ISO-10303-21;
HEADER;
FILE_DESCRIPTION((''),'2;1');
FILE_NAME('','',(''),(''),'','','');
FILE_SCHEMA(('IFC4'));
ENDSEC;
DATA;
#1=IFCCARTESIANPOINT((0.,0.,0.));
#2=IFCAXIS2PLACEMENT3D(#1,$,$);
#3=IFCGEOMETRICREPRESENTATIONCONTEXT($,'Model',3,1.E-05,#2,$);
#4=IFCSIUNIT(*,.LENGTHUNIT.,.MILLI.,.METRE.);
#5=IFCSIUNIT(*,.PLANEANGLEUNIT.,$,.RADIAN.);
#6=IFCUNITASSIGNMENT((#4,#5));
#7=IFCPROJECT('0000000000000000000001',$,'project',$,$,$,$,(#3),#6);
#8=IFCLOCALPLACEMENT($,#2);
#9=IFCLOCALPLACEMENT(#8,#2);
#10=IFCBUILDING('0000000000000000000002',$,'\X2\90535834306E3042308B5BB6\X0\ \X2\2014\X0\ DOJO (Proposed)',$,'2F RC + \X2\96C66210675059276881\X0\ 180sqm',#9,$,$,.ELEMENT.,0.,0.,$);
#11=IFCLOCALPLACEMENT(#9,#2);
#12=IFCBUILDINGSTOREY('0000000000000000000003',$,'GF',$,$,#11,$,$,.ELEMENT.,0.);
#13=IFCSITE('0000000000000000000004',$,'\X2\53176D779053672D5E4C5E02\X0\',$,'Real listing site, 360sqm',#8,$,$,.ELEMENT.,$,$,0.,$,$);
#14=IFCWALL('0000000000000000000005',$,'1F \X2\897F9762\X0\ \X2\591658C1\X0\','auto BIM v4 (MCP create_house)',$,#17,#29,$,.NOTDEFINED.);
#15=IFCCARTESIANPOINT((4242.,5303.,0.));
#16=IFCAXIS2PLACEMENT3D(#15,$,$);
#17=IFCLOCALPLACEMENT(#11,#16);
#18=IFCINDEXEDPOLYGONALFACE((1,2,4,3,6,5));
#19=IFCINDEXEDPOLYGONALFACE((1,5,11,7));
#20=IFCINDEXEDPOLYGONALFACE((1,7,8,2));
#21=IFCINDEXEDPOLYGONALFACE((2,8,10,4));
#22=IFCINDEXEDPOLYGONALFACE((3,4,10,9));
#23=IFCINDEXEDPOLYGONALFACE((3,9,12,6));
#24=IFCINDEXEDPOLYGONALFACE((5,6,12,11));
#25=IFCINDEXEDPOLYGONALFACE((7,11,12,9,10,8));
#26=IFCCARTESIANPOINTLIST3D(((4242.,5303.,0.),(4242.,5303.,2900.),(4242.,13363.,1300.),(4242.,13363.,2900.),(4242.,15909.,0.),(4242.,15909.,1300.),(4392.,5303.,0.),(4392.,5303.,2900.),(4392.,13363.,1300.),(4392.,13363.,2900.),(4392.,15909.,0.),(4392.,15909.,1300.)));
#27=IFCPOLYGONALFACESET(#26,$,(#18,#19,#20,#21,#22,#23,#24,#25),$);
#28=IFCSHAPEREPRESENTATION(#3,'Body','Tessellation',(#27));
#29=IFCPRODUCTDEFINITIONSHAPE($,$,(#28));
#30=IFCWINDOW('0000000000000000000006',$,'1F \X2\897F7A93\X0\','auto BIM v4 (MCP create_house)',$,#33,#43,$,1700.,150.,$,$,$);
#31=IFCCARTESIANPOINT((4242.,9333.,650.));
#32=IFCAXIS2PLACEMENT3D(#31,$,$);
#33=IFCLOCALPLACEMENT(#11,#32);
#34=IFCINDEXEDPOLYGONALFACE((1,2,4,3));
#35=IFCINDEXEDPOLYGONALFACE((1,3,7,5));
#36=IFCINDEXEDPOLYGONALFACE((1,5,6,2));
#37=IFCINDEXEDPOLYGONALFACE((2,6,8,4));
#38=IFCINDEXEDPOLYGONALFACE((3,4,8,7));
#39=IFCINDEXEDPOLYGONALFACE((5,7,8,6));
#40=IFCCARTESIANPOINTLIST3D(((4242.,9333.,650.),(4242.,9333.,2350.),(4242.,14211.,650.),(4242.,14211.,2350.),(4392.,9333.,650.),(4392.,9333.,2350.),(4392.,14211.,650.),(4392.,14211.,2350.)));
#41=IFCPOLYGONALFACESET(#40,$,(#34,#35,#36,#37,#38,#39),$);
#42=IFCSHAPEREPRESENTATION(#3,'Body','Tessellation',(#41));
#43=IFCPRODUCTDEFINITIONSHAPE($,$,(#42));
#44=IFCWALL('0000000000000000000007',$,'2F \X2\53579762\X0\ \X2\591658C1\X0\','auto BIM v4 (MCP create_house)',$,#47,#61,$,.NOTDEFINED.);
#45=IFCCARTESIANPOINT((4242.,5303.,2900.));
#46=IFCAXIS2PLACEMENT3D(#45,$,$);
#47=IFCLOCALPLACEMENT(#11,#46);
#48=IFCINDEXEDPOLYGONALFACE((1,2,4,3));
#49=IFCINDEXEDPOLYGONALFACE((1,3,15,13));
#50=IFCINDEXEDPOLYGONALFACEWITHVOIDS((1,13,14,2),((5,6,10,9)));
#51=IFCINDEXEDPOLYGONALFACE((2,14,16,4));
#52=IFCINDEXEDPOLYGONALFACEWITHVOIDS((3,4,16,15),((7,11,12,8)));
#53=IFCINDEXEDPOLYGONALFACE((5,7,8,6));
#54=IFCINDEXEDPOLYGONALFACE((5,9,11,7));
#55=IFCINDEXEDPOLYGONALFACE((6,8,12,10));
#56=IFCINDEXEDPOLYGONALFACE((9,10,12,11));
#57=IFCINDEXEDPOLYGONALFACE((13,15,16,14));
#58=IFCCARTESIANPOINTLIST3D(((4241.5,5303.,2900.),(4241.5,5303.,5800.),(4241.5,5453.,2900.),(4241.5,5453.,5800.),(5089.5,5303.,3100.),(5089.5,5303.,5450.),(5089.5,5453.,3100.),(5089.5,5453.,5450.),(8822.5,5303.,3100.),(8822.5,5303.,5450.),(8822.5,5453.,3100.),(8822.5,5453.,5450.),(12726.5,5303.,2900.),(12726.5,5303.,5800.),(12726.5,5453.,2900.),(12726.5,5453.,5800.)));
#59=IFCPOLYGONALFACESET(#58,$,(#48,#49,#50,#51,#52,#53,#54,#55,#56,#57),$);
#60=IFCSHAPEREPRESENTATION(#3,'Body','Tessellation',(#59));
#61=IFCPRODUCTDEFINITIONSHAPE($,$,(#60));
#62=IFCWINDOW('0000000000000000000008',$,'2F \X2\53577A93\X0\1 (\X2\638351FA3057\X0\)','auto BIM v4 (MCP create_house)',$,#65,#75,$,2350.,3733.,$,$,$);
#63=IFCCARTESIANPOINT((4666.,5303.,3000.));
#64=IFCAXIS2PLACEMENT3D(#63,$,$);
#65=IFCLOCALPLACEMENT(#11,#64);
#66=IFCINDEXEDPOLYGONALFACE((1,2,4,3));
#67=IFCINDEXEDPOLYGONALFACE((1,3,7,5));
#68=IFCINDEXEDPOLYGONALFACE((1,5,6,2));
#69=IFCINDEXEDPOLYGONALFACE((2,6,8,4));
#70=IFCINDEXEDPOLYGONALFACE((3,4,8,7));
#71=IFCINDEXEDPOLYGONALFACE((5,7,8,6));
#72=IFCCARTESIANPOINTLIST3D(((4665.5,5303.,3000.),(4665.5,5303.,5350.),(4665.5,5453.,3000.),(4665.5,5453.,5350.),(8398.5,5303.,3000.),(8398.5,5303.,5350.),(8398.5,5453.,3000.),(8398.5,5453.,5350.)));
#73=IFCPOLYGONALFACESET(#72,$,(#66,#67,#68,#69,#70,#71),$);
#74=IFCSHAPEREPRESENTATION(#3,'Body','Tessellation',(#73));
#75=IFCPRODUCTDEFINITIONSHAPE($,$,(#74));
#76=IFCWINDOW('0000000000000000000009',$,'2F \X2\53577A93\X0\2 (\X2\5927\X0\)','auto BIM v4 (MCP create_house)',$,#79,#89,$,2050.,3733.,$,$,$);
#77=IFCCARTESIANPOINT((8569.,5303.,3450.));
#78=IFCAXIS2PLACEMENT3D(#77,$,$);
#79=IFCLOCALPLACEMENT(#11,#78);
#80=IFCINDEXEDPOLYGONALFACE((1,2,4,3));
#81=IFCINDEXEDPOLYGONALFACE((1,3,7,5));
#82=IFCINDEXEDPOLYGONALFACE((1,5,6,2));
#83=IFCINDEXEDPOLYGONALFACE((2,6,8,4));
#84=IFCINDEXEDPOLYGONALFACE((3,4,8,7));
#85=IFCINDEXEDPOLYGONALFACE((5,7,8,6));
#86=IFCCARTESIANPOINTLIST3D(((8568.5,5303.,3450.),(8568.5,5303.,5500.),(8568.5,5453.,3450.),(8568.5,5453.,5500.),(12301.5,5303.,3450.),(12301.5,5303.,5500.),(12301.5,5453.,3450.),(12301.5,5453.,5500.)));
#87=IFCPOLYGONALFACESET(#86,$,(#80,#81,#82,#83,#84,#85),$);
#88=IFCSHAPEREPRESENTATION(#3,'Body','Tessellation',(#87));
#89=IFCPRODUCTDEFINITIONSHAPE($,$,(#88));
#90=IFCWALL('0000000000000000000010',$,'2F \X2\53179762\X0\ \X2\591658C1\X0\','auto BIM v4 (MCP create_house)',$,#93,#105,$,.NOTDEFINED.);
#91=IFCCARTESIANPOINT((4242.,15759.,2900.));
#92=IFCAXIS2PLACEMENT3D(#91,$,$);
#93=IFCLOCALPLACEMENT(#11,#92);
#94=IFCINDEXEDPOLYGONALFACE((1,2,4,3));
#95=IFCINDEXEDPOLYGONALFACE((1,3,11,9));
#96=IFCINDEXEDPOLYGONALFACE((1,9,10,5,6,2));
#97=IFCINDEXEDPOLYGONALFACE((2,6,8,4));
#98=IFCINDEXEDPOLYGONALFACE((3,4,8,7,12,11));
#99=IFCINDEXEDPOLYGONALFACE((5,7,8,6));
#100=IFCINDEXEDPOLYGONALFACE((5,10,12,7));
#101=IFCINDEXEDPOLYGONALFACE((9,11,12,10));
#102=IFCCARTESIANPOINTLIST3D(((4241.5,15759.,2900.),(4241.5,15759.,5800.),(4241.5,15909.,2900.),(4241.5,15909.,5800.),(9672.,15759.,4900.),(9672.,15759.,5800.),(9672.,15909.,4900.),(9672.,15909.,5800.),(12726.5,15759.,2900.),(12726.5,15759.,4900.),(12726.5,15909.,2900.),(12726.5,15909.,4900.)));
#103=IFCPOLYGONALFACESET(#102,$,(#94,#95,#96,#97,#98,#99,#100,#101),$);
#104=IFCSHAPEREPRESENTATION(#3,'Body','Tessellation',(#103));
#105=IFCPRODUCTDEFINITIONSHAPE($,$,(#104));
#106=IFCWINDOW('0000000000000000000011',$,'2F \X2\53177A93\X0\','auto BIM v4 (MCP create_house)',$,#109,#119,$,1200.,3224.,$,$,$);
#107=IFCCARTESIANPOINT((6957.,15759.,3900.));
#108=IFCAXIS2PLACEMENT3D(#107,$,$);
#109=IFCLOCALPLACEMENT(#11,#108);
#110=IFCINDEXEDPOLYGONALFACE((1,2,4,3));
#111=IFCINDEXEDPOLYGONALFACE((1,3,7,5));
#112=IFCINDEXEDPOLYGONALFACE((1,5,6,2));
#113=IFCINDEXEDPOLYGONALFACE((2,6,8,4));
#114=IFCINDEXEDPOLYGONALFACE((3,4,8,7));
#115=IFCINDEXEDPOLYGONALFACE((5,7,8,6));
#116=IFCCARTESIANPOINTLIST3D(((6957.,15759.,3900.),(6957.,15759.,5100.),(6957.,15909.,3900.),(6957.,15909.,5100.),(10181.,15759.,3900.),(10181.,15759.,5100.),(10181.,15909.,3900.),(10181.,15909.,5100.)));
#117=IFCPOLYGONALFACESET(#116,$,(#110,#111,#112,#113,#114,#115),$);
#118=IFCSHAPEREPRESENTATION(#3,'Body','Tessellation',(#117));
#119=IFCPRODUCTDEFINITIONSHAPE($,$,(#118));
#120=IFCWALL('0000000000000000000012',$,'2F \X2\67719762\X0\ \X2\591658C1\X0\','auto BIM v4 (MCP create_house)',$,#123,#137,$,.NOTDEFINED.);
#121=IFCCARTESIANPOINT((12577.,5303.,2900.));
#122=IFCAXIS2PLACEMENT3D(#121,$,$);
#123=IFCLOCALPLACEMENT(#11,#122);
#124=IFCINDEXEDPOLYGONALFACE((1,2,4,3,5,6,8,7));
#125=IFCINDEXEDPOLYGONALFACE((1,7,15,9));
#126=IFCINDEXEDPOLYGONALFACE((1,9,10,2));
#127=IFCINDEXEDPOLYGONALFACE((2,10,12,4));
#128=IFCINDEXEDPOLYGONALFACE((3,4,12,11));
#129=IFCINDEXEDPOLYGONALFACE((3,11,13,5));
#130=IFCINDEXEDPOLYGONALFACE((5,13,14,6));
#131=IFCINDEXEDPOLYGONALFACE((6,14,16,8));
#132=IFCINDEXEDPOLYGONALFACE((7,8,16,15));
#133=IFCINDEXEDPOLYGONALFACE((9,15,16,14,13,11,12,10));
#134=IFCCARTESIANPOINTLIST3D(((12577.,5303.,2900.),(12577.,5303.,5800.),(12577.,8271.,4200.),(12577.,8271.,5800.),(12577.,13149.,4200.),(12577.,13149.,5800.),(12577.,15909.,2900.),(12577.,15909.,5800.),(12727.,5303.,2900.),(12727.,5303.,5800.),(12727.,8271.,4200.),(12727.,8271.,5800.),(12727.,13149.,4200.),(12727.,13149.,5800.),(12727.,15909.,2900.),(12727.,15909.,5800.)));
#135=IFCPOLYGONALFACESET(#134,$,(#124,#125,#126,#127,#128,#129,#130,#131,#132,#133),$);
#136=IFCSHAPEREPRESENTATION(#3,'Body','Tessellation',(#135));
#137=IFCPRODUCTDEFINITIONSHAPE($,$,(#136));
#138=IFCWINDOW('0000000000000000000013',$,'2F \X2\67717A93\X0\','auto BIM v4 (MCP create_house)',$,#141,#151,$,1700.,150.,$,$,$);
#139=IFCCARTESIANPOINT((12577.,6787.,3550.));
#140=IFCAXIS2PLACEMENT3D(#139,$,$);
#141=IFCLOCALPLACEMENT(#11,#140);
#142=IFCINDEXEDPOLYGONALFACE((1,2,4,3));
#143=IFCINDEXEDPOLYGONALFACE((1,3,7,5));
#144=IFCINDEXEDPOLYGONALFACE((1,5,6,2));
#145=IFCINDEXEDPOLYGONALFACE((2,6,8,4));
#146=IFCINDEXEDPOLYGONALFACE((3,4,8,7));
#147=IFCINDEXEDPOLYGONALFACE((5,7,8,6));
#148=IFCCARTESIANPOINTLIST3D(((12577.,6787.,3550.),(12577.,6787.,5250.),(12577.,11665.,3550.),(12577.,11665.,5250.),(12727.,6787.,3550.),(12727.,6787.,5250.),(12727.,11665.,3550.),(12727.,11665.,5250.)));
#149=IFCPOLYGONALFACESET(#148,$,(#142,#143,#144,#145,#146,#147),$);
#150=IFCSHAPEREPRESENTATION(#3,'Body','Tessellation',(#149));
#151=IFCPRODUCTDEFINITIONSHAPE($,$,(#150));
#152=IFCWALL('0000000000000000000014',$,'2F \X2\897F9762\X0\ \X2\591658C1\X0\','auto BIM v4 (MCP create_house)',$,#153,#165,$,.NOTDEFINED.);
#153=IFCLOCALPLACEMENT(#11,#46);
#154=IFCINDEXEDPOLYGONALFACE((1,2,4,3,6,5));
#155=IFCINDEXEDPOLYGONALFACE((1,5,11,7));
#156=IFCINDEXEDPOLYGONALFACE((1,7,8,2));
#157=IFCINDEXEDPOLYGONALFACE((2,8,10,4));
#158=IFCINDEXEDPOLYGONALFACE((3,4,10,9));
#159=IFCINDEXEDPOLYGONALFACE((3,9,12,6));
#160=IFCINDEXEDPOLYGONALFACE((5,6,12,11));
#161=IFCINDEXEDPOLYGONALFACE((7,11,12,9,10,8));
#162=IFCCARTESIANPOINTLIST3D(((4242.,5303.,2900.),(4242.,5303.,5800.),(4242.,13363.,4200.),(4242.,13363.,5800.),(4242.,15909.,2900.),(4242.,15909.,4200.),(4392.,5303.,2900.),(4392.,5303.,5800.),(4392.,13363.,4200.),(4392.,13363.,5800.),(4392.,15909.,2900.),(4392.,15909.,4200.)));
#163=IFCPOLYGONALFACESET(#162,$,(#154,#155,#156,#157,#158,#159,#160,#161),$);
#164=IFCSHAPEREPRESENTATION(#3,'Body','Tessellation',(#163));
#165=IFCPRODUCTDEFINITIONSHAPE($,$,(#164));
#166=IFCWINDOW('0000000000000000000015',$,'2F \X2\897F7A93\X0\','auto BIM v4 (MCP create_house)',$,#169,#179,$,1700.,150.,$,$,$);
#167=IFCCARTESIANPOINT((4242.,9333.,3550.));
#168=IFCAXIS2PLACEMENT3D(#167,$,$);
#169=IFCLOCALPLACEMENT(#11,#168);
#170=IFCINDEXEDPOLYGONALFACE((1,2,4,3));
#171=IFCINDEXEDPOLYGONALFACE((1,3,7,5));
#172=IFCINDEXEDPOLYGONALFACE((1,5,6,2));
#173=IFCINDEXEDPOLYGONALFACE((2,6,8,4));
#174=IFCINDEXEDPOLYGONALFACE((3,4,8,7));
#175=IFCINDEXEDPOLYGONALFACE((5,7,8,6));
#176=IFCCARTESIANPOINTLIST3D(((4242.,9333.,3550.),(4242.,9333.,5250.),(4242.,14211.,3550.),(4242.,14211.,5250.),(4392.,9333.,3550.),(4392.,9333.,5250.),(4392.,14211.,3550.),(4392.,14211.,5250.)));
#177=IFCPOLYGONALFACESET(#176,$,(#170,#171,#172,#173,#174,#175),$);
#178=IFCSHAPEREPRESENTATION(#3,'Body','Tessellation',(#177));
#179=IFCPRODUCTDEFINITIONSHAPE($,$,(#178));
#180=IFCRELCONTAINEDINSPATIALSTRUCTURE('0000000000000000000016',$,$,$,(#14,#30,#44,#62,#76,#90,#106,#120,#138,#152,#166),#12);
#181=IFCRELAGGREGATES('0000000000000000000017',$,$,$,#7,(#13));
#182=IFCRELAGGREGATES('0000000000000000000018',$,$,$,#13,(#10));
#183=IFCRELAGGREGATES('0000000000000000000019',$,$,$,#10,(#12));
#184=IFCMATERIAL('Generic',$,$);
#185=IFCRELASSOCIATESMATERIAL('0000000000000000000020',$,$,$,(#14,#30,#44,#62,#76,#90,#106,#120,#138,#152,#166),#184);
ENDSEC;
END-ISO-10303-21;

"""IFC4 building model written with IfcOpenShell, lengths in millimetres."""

from ifc_helpers import new_model, si_unit, frame, frame_2d, origin, place, context, project, spatial, rectangle, extrude, material, element, fill, save


model = new_model("IFC4")

# Units and contexts
model_context = context("Model", 3, precision=1e-05, world=origin())
ifc_project = project(units=[si_unit("LENGTHUNIT", "METRE", prefix="MILLI"), si_unit("PLANEANGLEUNIT", "RADIAN")], contexts=[model_context])

# Site, building, storey
site_placement = place(None, origin())
site = spatial("IfcSite", under=ifc_project, at=site_placement, Name="北海道札幌市", ObjectType="Real listing site, 360sqm", CompositionType="ELEMENT", RefElevation=0.0)
building_placement = place(site_placement, origin())
building = spatial("IfcBuilding", under=site, at=building_placement, Name="道場のある家 — DOJO (Proposed)", ObjectType="2F RC + 集成材大梁 180sqm", CompositionType="ELEMENT", ElevationOfRefHeight=0.0, ElevationOfTerrain=0.0)
storey_placement = place(building_placement, origin())
storey = spatial("IfcBuildingStorey", under=building, at=storey_placement, Name="GF", CompositionType="ELEMENT", Elevation=0.0)

# Shared definitions
ifc_material = material(Name="Generic")

# Wall, opening, window
wall_1_placement = place(storey_placement, frame((4242.0, 5303.0, 0.0)))
wall_1 = element("IfcWall", 1, at=wall_1_placement, inside=storey, material=ifc_material, Name="1F 西面 外壁", Description="auto BIM v4 (MCP create_house)", PredefinedType="NOTDEFINED", context=model_context, shape_type="SweptSolid", body=[
    extrude(rectangle(XDim=150.0, YDim=10606.0, at=frame_2d((75.0, 5303.0))), frame((4242.0, 5303.0, 0.0)), (0.0, 0.0, 1.0), 2900.0),
])
opening_1_placement = place(storey_placement, frame((4242.0, 9333.0, 650.0)))
opening_1 = element("IfcOpeningElement", 2, at=opening_1_placement, cuts=wall_1, PredefinedType="NOTDEFINED", context=model_context, shape_type="SweptSolid", body=[
    extrude(rectangle(XDim=150.0, YDim=4878.0, at=frame_2d((75.0, 2439.0))), frame((4242.0, 9333.0, 650.0)), (0.0, 0.0, 1.0), 1700.0),
])
window_1_placement = place(storey_placement, frame((4242.0, 9333.0, 650.0)))
window_1 = element("IfcWindow", 3, at=window_1_placement, inside=storey, material=ifc_material, Name="1F 西窓", Description="auto BIM v4 (MCP create_house)", OverallHeight=1700.0, OverallWidth=150.0, context=model_context, shape_type="SweptSolid", body=[
    extrude(rectangle(XDim=150.0, YDim=4878.0, at=frame_2d((75.0, 2439.0))), frame((4242.0, 9333.0, 650.0)), (0.0, 0.0, 1.0), 1700.0),
])
fill(opening_1, window_1)

# Wall, openings, windows
wall_2_placement = place(storey_placement, frame((4242.0, 5303.0, 2900.0)))
wall_2 = element("IfcWall", 4, at=wall_2_placement, inside=storey, material=ifc_material, Name="2F 南面 外壁", Description="auto BIM v4 (MCP create_house)", PredefinedType="NOTDEFINED", context=model_context, shape_type="SweptSolid", body=[
    extrude(rectangle(XDim=8485.0, YDim=150.0, at=frame_2d((4242.0, 75.0))), frame((4242.0, 5303.0, 2900.0)), (0.0, 0.0, 1.0), 2900.0),
])
opening_2_placement = place(storey_placement, frame((4666.0, 5303.0, 3000.0)))
opening_2 = element("IfcOpeningElement", 5, at=opening_2_placement, cuts=wall_2, PredefinedType="NOTDEFINED", context=model_context, shape_type="SweptSolid", body=[
    extrude(rectangle(XDim=3733.0, YDim=150.0, at=frame_2d((1866.0, 75.0))), frame((4666.0, 5303.0, 3000.0)), (0.0, 0.0, 1.0), 2350.0),
])
opening_3_placement = place(storey_placement, frame((8569.0, 5303.0, 3450.0)))
opening_3 = element("IfcOpeningElement", 6, at=opening_3_placement, cuts=wall_2, PredefinedType="NOTDEFINED", context=model_context, shape_type="SweptSolid", body=[
    extrude(rectangle(XDim=3733.0, YDim=150.0, at=frame_2d((1866.0, 75.0))), frame((8569.0, 5303.0, 3450.0)), (0.0, 0.0, 1.0), 2050.0),
])
window_2_placement = place(storey_placement, frame((4666.0, 5303.0, 3000.0)))
window_2 = element("IfcWindow", 7, at=window_2_placement, inside=storey, material=ifc_material, Name="2F 南窓1 (掃出し)", Description="auto BIM v4 (MCP create_house)", OverallHeight=2350.0, OverallWidth=3733.0, context=model_context, shape_type="SweptSolid", body=[
    extrude(rectangle(XDim=3733.0, YDim=150.0, at=frame_2d((1866.0, 75.0))), frame((4666.0, 5303.0, 3000.0)), (0.0, 0.0, 1.0), 2350.0),
])
fill(opening_2, window_2)
window_3_placement = place(storey_placement, frame((8569.0, 5303.0, 3450.0)))
window_3 = element("IfcWindow", 8, at=window_3_placement, inside=storey, material=ifc_material, Name="2F 南窓2 (大)", Description="auto BIM v4 (MCP create_house)", OverallHeight=2050.0, OverallWidth=3733.0, context=model_context, shape_type="SweptSolid", body=[
    extrude(rectangle(XDim=3733.0, YDim=150.0, at=frame_2d((1866.0, 75.0))), frame((8569.0, 5303.0, 3450.0)), (0.0, 0.0, 1.0), 2050.0),
])
fill(opening_3, window_3)

# Walls, openings, windows
wall_3_placement = place(storey_placement, frame((4242.0, 15759.0, 2900.0)))
wall_3 = element("IfcWall", 9, at=wall_3_placement, inside=storey, material=ifc_material, Name="2F 北面 外壁", Description="auto BIM v4 (MCP create_house)", PredefinedType="NOTDEFINED", context=model_context, shape_type="SweptSolid", body=[
    extrude(rectangle(XDim=8485.0, YDim=150.0, at=frame_2d((4242.0, 75.0))), frame((4242.0, 15759.0, 2900.0)), (0.0, 0.0, 1.0), 2900.0),
])
opening_4_placement = place(storey_placement, frame((6957.0, 15759.0, 3900.0)))
opening_4 = element("IfcOpeningElement", 10, at=opening_4_placement, cuts=wall_3, PredefinedType="NOTDEFINED", context=model_context, shape_type="SweptSolid", body=[
    extrude(rectangle(XDim=3224.0, YDim=150.0, at=frame_2d((1612.0, 75.0))), frame((6957.0, 15759.0, 3900.0)), (0.0, 0.0, 1.0), 1200.0),
])
window_4_placement = place(storey_placement, frame((6957.0, 15759.0, 3900.0)))
window_4 = element("IfcWindow", 11, at=window_4_placement, inside=storey, material=ifc_material, Name="2F 北窓", Description="auto BIM v4 (MCP create_house)", OverallHeight=1200.0, OverallWidth=3224.0, context=model_context, shape_type="SweptSolid", body=[
    extrude(rectangle(XDim=3224.0, YDim=150.0, at=frame_2d((1612.0, 75.0))), frame((6957.0, 15759.0, 3900.0)), (0.0, 0.0, 1.0), 1200.0),
])
fill(opening_4, window_4)
wall_4_placement = place(storey_placement, frame((12577.0, 5303.0, 2900.0)))
wall_4 = element("IfcWall", 12, at=wall_4_placement, inside=storey, material=ifc_material, Name="2F 東面 外壁", Description="auto BIM v4 (MCP create_house)", PredefinedType="NOTDEFINED", context=model_context, shape_type="SweptSolid", body=[
    extrude(rectangle(XDim=150.0, YDim=10606.0, at=frame_2d((75.0, 5303.0))), frame((12577.0, 5303.0, 2900.0)), (0.0, 0.0, 1.0), 2900.0),
])
opening_5_placement = place(storey_placement, frame((12577.0, 6787.0, 3550.0)))
opening_5 = element("IfcOpeningElement", 13, at=opening_5_placement, cuts=wall_4, PredefinedType="NOTDEFINED", context=model_context, shape_type="SweptSolid", body=[
    extrude(rectangle(XDim=150.0, YDim=4878.0, at=frame_2d((75.0, 2439.0))), frame((12577.0, 6787.0, 3550.0)), (0.0, 0.0, 1.0), 1700.0),
])
window_5_placement = place(storey_placement, frame((12577.0, 6787.0, 3550.0)))
window_5 = element("IfcWindow", 14, at=window_5_placement, inside=storey, material=ifc_material, Name="2F 東窓", Description="auto BIM v4 (MCP create_house)", OverallHeight=1700.0, OverallWidth=150.0, context=model_context, shape_type="SweptSolid", body=[
    extrude(rectangle(XDim=150.0, YDim=4878.0, at=frame_2d((75.0, 2439.0))), frame((12577.0, 6787.0, 3550.0)), (0.0, 0.0, 1.0), 1700.0),
])
fill(opening_5, window_5)
wall_5_placement = place(storey_placement, frame((4242.0, 5303.0, 2900.0)))
wall_5 = element("IfcWall", 15, at=wall_5_placement, inside=storey, material=ifc_material, Name="2F 西面 外壁", Description="auto BIM v4 (MCP create_house)", PredefinedType="NOTDEFINED", context=model_context, shape_type="SweptSolid", body=[
    extrude(rectangle(XDim=150.0, YDim=10606.0, at=frame_2d((75.0, 5303.0))), frame((4242.0, 5303.0, 2900.0)), (0.0, 0.0, 1.0), 2900.0),
])
opening_6_placement = place(storey_placement, frame((4242.0, 9333.0, 3550.0)))
opening_6 = element("IfcOpeningElement", 16, at=opening_6_placement, cuts=wall_5, PredefinedType="NOTDEFINED", context=model_context, shape_type="SweptSolid", body=[
    extrude(rectangle(XDim=150.0, YDim=4878.0, at=frame_2d((75.0, 2439.0))), frame((4242.0, 9333.0, 3550.0)), (0.0, 0.0, 1.0), 1700.0),
])
window_6_placement = place(storey_placement, frame((4242.0, 9333.0, 3550.0)))
window_6 = element("IfcWindow", 17, at=window_6_placement, inside=storey, material=ifc_material, Name="2F 西窓", Description="auto BIM v4 (MCP create_house)", OverallHeight=1700.0, OverallWidth=150.0, context=model_context, shape_type="SweptSolid", body=[
    extrude(rectangle(XDim=150.0, YDim=4878.0, at=frame_2d((75.0, 2439.0))), frame((4242.0, 9333.0, 3550.0)), (0.0, 0.0, 1.0), 1700.0),
])
fill(opening_6, window_6)

save(model, "model.ifc")
